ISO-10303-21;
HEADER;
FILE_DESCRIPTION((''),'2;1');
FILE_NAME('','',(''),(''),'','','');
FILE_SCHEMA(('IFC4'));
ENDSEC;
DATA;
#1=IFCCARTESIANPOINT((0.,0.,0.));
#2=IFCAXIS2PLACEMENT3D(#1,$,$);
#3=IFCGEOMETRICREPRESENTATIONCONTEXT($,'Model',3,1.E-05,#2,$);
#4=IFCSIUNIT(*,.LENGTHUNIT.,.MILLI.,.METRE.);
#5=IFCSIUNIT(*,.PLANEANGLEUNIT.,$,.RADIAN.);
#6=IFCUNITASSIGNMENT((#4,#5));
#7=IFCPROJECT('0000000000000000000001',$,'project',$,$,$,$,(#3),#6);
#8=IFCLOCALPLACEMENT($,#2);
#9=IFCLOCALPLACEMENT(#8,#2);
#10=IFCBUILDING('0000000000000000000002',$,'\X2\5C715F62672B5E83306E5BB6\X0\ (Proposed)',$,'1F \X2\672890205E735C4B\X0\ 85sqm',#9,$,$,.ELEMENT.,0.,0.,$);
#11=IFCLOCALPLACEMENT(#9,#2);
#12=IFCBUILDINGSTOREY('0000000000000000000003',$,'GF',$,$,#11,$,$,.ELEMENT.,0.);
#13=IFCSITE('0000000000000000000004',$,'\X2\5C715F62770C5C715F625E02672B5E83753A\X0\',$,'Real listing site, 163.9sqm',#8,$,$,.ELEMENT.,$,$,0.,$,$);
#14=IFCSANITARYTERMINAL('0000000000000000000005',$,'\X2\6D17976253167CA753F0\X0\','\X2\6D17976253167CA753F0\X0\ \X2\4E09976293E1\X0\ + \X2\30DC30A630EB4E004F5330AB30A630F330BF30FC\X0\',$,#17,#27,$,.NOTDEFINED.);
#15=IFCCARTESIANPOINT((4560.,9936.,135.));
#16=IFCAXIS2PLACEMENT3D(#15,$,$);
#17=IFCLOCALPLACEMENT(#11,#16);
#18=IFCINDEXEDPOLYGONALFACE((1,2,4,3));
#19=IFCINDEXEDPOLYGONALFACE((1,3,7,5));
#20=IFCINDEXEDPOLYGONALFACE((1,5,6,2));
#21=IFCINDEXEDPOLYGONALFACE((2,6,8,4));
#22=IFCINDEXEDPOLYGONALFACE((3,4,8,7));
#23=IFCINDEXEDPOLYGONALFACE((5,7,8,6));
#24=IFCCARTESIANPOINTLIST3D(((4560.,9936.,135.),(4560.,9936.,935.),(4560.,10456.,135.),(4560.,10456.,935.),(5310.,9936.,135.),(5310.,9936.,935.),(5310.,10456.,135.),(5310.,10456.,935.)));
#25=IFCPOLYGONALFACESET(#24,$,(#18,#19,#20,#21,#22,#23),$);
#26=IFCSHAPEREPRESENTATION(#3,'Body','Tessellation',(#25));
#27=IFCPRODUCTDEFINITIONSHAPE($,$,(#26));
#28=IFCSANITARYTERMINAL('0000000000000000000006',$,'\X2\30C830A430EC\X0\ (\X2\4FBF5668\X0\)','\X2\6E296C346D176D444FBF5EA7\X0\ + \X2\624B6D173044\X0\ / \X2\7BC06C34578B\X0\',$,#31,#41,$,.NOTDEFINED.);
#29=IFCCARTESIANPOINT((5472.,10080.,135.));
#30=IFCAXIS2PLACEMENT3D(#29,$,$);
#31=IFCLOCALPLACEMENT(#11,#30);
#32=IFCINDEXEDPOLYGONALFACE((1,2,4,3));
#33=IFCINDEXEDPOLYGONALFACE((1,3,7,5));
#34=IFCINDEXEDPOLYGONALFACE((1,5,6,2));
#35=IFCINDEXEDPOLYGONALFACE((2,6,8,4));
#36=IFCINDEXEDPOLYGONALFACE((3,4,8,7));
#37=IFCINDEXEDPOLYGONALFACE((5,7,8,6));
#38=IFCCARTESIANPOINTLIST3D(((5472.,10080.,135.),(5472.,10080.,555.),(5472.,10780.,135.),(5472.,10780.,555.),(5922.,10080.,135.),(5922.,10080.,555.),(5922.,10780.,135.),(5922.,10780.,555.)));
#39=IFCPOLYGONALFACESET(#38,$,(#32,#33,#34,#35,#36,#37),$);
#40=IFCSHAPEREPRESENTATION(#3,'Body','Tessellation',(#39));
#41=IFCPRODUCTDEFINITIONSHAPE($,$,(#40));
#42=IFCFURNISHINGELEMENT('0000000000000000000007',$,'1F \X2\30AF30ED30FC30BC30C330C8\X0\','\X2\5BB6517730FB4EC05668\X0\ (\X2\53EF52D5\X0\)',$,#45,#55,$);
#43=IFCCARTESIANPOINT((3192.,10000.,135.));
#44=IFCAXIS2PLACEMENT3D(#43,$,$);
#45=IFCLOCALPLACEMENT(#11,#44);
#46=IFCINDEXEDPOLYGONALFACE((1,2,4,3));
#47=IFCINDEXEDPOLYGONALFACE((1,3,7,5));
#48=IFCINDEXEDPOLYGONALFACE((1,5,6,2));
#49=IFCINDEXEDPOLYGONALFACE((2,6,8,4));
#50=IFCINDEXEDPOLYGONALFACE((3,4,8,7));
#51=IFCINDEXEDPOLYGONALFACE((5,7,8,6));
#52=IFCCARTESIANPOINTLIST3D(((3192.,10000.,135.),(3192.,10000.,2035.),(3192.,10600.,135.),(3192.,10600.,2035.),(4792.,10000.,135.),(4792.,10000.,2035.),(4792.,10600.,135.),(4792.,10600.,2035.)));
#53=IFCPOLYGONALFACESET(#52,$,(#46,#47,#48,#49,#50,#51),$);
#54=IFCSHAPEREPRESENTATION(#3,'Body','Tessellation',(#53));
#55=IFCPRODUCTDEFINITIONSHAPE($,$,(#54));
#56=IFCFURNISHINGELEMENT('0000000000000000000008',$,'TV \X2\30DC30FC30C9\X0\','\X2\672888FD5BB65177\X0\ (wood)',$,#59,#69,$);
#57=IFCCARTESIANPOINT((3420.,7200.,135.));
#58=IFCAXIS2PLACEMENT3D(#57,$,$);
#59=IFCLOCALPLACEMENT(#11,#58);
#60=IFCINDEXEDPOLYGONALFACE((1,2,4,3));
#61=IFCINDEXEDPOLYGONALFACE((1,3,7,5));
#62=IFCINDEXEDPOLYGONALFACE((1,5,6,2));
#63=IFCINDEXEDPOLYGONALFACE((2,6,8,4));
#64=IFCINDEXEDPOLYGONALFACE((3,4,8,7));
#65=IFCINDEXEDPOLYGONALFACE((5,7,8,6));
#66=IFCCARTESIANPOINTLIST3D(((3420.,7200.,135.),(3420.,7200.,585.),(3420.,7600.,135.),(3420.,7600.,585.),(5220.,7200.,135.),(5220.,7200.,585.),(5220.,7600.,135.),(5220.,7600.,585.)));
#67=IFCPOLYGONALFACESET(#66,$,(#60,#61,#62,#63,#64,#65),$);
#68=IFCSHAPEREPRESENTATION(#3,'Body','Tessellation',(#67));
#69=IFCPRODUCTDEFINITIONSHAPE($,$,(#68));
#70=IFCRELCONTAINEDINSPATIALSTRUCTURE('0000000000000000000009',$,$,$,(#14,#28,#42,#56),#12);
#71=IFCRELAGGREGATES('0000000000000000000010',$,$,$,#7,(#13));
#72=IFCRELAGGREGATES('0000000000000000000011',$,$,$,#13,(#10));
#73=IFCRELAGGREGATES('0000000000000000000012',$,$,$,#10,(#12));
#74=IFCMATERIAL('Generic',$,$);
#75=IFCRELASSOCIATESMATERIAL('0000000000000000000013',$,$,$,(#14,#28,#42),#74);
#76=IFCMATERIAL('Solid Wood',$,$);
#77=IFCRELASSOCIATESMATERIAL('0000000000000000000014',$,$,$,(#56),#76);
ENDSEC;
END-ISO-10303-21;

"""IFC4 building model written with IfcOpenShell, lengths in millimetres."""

from ifc_helpers import new_model, si_unit, frame, frame_2d, origin, place, context, project, spatial, rectangle, extrude, material, element, save


model = new_model("IFC4")

# Units and contexts
model_context = context("Model", 3, precision=1e-05, world=origin())
ifc_project = project(units=[si_unit("LENGTHUNIT", "METRE", prefix="MILLI"), si_unit("PLANEANGLEUNIT", "RADIAN")], contexts=[model_context])

# Site, building, storey
site_placement = place(None, origin())
site = spatial("IfcSite", under=ifc_project, at=site_placement, Name="山形県山形市末広町", ObjectType="Real listing site, 163.9sqm", CompositionType="ELEMENT", RefElevation=0.0)
building_placement = place(site_placement, origin())
building = spatial("IfcBuilding", under=site, at=building_placement, Name="山形末広の家 (Proposed)", ObjectType="1F 木造平屋 85sqm", CompositionType="ELEMENT", ElevationOfRefHeight=0.0, ElevationOfTerrain=0.0)
storey_placement = place(building_placement, origin())
storey = spatial("IfcBuildingStorey", under=building, at=storey_placement, Name="GF", CompositionType="ELEMENT", Elevation=0.0)

# Shared definitions
ifc_material_1 = material(Name="Solid Wood")

# Shared definitions
ifc_material_2 = material(Name="Generic")

# Sanitary terminals
sanitary_terminal_1_placement = place(storey_placement, frame((4560.0, 9936.0, 135.0)))
element("IfcSanitaryTerminal", 1, at=sanitary_terminal_1_placement, inside=storey, material=ifc_material_2, Name="洗面化粧台", Description="洗面化粧台 三面鏡 + ボウル一体カウンター", PredefinedType="NOTDEFINED", context=model_context, shape_type="SweptSolid", body=[
    extrude(rectangle(XDim=750.0, YDim=520.0, at=frame_2d((375.0, 260.0))), frame((4560.0, 9936.0, 135.0)), (0.0, 0.0, 1.0), 800.0),
])
sanitary_terminal_2_placement = place(storey_placement, frame((5472.0, 10080.0, 135.0)))
element("IfcSanitaryTerminal", 2, at=sanitary_terminal_2_placement, inside=storey, material=ifc_material_2, Name="トイレ (便器)", Description="温水洗浄便座 + 手洗い / 節水型", PredefinedType="NOTDEFINED", context=model_context, shape_type="SweptSolid", body=[
    extrude(rectangle(XDim=450.0, YDim=700.0, at=frame_2d((225.0, 350.0))), frame((5472.0, 10080.0, 135.0)), (0.0, 0.0, 1.0), 420.0),
])

# Furnishing elements
furnishing_1_placement = place(storey_placement, frame((3192.0, 10000.0, 135.0)))
element("IfcFurnishingElement", 3, at=furnishing_1_placement, inside=storey, material=ifc_material_2, Name="1F クローゼット", Description="家具・什器 (可動)", context=model_context, shape_type="SweptSolid", body=[
    extrude(rectangle(XDim=1600.0, YDim=600.0, at=frame_2d((800.0, 300.0))), frame((3192.0, 10000.0, 135.0)), (0.0, 0.0, 1.0), 1900.0),
])
furnishing_2_placement = place(storey_placement, frame((3420.0, 7200.0, 135.0)))
element("IfcFurnishingElement", 4, at=furnishing_2_placement, inside=storey, material=ifc_material_1, Name="TV ボード", Description="木製家具 (wood)", context=model_context, shape_type="SweptSolid", body=[
    extrude(rectangle(XDim=1800.0, YDim=400.0, at=frame_2d((900.0, 200.0))), frame((3420.0, 7200.0, 135.0)), (0.0, 0.0, 1.0), 450.0),
])

save(model, "model.ifc")
